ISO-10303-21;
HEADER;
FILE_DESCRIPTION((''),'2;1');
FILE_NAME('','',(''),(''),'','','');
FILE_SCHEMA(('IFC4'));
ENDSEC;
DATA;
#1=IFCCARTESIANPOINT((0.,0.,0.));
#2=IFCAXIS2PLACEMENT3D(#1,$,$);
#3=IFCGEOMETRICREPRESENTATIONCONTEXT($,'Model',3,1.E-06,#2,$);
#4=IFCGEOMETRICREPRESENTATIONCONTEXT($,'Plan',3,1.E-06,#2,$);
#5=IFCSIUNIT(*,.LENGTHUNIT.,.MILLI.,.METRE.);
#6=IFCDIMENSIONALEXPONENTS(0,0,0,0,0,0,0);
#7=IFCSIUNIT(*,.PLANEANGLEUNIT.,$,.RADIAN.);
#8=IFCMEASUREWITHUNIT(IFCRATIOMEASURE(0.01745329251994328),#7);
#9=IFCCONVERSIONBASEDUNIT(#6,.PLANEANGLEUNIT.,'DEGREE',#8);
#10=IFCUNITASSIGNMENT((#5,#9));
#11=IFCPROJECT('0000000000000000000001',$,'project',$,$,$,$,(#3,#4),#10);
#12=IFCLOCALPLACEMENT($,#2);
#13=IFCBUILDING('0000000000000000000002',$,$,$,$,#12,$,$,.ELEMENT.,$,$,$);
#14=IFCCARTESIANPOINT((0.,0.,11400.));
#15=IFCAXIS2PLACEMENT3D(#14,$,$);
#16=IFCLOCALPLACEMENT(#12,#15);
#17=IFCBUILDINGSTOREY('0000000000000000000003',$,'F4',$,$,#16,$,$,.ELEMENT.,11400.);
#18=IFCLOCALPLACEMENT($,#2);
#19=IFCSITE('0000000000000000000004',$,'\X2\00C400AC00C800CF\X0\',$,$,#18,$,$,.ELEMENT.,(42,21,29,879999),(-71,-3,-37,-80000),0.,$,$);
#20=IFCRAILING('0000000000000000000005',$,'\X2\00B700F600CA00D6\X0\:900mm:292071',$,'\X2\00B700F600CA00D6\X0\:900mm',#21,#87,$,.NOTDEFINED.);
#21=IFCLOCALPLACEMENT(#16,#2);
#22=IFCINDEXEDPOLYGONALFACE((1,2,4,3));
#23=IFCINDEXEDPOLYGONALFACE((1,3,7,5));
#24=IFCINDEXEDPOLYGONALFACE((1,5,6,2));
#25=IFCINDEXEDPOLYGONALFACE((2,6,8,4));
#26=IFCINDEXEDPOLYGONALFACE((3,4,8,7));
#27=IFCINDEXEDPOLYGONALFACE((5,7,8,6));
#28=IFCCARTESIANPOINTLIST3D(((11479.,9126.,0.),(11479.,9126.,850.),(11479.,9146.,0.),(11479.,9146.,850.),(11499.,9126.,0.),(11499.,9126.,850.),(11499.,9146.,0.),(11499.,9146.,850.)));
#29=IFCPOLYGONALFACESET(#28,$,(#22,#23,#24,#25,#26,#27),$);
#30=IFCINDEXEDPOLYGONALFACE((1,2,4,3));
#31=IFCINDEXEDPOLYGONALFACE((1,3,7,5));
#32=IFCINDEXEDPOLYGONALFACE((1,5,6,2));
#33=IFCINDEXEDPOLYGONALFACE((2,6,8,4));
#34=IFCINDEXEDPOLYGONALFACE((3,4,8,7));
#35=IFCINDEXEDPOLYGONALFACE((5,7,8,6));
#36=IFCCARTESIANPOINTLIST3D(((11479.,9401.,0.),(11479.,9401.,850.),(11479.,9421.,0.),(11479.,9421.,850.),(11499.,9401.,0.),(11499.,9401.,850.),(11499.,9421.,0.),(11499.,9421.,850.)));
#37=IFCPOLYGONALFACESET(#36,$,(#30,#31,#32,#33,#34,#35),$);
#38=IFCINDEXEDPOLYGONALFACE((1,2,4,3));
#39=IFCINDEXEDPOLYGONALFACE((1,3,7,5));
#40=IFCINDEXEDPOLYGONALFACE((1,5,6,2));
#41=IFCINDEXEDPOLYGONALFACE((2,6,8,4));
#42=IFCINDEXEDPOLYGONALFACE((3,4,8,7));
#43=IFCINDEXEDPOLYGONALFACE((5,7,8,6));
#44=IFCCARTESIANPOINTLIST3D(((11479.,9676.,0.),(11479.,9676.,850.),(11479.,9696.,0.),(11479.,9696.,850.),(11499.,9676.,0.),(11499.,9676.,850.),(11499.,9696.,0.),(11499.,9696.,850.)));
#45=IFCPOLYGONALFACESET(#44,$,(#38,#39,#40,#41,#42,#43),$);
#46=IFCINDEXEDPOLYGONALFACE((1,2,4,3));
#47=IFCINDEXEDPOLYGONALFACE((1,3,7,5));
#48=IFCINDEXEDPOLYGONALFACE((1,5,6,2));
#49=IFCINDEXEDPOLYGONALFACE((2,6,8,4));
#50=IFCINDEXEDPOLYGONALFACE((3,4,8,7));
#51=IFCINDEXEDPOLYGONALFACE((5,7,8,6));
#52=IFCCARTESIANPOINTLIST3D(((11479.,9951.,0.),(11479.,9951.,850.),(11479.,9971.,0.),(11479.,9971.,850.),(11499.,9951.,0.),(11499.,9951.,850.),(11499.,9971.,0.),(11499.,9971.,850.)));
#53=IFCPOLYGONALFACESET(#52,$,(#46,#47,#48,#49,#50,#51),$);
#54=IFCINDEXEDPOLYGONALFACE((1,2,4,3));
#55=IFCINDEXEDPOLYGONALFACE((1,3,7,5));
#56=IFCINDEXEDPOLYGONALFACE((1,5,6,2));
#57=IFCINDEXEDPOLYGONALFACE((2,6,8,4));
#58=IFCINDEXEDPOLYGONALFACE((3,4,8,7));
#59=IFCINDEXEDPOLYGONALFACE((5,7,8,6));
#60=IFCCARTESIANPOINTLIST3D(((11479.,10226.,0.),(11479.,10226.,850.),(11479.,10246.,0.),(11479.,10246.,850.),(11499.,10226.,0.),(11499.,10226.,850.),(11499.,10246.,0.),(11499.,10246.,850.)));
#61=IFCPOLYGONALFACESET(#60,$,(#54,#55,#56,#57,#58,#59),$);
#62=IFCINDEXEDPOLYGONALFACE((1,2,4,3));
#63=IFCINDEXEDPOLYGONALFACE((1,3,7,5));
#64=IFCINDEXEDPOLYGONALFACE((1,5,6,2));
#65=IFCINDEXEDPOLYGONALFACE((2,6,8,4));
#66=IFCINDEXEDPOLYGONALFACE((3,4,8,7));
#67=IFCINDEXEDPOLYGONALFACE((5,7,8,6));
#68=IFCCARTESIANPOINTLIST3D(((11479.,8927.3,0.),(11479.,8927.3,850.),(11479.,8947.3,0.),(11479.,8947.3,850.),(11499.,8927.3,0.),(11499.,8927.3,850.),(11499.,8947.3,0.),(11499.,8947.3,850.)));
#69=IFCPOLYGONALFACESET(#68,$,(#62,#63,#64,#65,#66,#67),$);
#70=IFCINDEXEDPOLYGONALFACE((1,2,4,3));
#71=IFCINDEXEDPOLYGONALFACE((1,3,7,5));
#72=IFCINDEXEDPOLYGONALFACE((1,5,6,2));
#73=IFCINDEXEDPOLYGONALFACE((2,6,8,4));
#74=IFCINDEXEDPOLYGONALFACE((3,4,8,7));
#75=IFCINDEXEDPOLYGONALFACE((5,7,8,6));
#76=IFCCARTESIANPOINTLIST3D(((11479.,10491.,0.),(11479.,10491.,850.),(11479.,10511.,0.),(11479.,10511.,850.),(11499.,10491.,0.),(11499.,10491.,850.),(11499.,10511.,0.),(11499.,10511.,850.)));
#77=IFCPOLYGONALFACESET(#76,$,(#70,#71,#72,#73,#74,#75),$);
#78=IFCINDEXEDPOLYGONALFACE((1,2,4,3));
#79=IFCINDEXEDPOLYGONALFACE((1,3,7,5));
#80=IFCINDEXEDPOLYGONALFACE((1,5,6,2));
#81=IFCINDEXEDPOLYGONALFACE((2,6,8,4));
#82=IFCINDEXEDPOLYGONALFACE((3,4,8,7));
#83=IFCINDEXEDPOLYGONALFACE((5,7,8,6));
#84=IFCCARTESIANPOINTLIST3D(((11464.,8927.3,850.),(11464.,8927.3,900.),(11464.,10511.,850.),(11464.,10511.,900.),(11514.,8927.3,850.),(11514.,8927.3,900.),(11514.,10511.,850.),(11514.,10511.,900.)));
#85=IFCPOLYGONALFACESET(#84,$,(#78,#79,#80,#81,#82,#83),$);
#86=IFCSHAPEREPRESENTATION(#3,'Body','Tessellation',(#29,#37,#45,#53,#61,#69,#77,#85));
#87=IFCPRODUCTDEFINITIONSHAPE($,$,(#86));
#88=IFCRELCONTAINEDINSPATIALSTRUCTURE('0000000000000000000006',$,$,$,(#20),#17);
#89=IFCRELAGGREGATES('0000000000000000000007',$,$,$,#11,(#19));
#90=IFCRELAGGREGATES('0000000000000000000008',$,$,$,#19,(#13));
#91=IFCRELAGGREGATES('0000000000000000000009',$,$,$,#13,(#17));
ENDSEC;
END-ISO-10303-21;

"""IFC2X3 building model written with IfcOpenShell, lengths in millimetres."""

from ifc_helpers import new_model, entity, si_unit, converted_unit, frame, origin, origin_2d_with_axis, place, context, project, spatial, rectangle, extrude, element, save


model = new_model("IFC2X3")

# Units and contexts
model_context = context("Model", 3, precision=1e-06, world=origin())
plan_context = context("Plan", 3, precision=1e-06, world=origin())
ifc_project = project(units=[si_unit("LENGTHUNIT", "METRE", prefix="MILLI"), converted_unit("PLANEANGLEUNIT", "DEGREE", entity("IfcRatioMeasure", 0.01745329251994328), si_unit("PLANEANGLEUNIT", "RADIAN"), dimensions=[0, 0, 0, 0, 0, 0, 0])], contexts=[model_context, plan_context])

# Site, building, storey
site_placement = place(None, origin())
site = spatial("IfcSite", under=ifc_project, at=site_placement, Name="Ä¬ÈÏ", CompositionType="ELEMENT", RefLatitude=(42, 21, 29, 879999), RefLongitude=(-71, -3, -37, -80000), RefElevation=0.0)
building_placement = place(None, origin())
building = spatial("IfcBuilding", under=site, at=building_placement, CompositionType="ELEMENT")
storey_placement = place(building_placement, frame((0.0, 0.0, 11400.0)))
storey = spatial("IfcBuildingStorey", under=building, at=storey_placement, Name="F4", CompositionType="ELEMENT", Elevation=11400.0)

# Railing
railing_1_placement = place(storey_placement, origin())
element("IfcRailing", 1, at=railing_1_placement, inside=storey, Name="·öÊÖ:900mm:292071", ObjectType="·öÊÖ:900mm", PredefinedType="NOTDEFINED", context=model_context, shape_type="SweptSolid", body=[
    extrude(rectangle(XDim=20.0, YDim=20.0, at=origin_2d_with_axis()), frame((11489.0, 9136.0, 0.0), z_axis=(0.0, 0.0, 1.0), x_axis=(0.0, -1.0, 0.0)), (0.0, 0.0, 1.0), 850.0),
    extrude(rectangle(XDim=20.0, YDim=20.0, at=origin_2d_with_axis()), frame((11489.0, 9411.0, 0.0), z_axis=(0.0, 0.0, 1.0), x_axis=(0.0, -1.0, 0.0)), (0.0, 0.0, 1.0), 850.0),
    extrude(rectangle(XDim=20.0, YDim=20.0, at=origin_2d_with_axis()), frame((11489.0, 9686.0, 0.0), z_axis=(0.0, 0.0, 1.0), x_axis=(0.0, -1.0, 0.0)), (0.0, 0.0, 1.0), 850.0),
    extrude(rectangle(XDim=20.0, YDim=20.0, at=origin_2d_with_axis()), frame((11489.0, 9961.0, 0.0), z_axis=(0.0, 0.0, 1.0), x_axis=(0.0, -1.0, 0.0)), (0.0, 0.0, 1.0), 850.0),
    extrude(rectangle(XDim=20.0, YDim=20.0, at=origin_2d_with_axis()), frame((11489.0, 10236.0, 0.0), z_axis=(0.0, 0.0, 1.0), x_axis=(0.0, -1.0, 0.0)), (0.0, 0.0, 1.0), 850.0),
    extrude(rectangle(XDim=20.0, YDim=20.0, at=origin_2d_with_axis()), frame((11489.0, 8937.3, 0.0), z_axis=(0.0, 0.0, 1.0), x_axis=(0.0, -1.0, 0.0)), (0.0, 0.0, 1.0), 850.0),
    extrude(rectangle(XDim=20.0, YDim=20.0, at=origin_2d_with_axis()), frame((11489.0, 10501.0, 0.0), z_axis=(0.0, 0.0, 1.0), x_axis=(0.0, -1.0, 0.0)), (0.0, 0.0, 1.0), 850.0),
    extrude(rectangle(XDim=1583.8, YDim=50.0, at=origin_2d_with_axis()), frame((11489.0, 9719.2, 850.0), z_axis=(0.0, 0.0, 1.0), x_axis=(0.0, -1.0, 0.0)), (0.0, 0.0, 1.0), 50.0),
])

save(model, "model.ifc")
